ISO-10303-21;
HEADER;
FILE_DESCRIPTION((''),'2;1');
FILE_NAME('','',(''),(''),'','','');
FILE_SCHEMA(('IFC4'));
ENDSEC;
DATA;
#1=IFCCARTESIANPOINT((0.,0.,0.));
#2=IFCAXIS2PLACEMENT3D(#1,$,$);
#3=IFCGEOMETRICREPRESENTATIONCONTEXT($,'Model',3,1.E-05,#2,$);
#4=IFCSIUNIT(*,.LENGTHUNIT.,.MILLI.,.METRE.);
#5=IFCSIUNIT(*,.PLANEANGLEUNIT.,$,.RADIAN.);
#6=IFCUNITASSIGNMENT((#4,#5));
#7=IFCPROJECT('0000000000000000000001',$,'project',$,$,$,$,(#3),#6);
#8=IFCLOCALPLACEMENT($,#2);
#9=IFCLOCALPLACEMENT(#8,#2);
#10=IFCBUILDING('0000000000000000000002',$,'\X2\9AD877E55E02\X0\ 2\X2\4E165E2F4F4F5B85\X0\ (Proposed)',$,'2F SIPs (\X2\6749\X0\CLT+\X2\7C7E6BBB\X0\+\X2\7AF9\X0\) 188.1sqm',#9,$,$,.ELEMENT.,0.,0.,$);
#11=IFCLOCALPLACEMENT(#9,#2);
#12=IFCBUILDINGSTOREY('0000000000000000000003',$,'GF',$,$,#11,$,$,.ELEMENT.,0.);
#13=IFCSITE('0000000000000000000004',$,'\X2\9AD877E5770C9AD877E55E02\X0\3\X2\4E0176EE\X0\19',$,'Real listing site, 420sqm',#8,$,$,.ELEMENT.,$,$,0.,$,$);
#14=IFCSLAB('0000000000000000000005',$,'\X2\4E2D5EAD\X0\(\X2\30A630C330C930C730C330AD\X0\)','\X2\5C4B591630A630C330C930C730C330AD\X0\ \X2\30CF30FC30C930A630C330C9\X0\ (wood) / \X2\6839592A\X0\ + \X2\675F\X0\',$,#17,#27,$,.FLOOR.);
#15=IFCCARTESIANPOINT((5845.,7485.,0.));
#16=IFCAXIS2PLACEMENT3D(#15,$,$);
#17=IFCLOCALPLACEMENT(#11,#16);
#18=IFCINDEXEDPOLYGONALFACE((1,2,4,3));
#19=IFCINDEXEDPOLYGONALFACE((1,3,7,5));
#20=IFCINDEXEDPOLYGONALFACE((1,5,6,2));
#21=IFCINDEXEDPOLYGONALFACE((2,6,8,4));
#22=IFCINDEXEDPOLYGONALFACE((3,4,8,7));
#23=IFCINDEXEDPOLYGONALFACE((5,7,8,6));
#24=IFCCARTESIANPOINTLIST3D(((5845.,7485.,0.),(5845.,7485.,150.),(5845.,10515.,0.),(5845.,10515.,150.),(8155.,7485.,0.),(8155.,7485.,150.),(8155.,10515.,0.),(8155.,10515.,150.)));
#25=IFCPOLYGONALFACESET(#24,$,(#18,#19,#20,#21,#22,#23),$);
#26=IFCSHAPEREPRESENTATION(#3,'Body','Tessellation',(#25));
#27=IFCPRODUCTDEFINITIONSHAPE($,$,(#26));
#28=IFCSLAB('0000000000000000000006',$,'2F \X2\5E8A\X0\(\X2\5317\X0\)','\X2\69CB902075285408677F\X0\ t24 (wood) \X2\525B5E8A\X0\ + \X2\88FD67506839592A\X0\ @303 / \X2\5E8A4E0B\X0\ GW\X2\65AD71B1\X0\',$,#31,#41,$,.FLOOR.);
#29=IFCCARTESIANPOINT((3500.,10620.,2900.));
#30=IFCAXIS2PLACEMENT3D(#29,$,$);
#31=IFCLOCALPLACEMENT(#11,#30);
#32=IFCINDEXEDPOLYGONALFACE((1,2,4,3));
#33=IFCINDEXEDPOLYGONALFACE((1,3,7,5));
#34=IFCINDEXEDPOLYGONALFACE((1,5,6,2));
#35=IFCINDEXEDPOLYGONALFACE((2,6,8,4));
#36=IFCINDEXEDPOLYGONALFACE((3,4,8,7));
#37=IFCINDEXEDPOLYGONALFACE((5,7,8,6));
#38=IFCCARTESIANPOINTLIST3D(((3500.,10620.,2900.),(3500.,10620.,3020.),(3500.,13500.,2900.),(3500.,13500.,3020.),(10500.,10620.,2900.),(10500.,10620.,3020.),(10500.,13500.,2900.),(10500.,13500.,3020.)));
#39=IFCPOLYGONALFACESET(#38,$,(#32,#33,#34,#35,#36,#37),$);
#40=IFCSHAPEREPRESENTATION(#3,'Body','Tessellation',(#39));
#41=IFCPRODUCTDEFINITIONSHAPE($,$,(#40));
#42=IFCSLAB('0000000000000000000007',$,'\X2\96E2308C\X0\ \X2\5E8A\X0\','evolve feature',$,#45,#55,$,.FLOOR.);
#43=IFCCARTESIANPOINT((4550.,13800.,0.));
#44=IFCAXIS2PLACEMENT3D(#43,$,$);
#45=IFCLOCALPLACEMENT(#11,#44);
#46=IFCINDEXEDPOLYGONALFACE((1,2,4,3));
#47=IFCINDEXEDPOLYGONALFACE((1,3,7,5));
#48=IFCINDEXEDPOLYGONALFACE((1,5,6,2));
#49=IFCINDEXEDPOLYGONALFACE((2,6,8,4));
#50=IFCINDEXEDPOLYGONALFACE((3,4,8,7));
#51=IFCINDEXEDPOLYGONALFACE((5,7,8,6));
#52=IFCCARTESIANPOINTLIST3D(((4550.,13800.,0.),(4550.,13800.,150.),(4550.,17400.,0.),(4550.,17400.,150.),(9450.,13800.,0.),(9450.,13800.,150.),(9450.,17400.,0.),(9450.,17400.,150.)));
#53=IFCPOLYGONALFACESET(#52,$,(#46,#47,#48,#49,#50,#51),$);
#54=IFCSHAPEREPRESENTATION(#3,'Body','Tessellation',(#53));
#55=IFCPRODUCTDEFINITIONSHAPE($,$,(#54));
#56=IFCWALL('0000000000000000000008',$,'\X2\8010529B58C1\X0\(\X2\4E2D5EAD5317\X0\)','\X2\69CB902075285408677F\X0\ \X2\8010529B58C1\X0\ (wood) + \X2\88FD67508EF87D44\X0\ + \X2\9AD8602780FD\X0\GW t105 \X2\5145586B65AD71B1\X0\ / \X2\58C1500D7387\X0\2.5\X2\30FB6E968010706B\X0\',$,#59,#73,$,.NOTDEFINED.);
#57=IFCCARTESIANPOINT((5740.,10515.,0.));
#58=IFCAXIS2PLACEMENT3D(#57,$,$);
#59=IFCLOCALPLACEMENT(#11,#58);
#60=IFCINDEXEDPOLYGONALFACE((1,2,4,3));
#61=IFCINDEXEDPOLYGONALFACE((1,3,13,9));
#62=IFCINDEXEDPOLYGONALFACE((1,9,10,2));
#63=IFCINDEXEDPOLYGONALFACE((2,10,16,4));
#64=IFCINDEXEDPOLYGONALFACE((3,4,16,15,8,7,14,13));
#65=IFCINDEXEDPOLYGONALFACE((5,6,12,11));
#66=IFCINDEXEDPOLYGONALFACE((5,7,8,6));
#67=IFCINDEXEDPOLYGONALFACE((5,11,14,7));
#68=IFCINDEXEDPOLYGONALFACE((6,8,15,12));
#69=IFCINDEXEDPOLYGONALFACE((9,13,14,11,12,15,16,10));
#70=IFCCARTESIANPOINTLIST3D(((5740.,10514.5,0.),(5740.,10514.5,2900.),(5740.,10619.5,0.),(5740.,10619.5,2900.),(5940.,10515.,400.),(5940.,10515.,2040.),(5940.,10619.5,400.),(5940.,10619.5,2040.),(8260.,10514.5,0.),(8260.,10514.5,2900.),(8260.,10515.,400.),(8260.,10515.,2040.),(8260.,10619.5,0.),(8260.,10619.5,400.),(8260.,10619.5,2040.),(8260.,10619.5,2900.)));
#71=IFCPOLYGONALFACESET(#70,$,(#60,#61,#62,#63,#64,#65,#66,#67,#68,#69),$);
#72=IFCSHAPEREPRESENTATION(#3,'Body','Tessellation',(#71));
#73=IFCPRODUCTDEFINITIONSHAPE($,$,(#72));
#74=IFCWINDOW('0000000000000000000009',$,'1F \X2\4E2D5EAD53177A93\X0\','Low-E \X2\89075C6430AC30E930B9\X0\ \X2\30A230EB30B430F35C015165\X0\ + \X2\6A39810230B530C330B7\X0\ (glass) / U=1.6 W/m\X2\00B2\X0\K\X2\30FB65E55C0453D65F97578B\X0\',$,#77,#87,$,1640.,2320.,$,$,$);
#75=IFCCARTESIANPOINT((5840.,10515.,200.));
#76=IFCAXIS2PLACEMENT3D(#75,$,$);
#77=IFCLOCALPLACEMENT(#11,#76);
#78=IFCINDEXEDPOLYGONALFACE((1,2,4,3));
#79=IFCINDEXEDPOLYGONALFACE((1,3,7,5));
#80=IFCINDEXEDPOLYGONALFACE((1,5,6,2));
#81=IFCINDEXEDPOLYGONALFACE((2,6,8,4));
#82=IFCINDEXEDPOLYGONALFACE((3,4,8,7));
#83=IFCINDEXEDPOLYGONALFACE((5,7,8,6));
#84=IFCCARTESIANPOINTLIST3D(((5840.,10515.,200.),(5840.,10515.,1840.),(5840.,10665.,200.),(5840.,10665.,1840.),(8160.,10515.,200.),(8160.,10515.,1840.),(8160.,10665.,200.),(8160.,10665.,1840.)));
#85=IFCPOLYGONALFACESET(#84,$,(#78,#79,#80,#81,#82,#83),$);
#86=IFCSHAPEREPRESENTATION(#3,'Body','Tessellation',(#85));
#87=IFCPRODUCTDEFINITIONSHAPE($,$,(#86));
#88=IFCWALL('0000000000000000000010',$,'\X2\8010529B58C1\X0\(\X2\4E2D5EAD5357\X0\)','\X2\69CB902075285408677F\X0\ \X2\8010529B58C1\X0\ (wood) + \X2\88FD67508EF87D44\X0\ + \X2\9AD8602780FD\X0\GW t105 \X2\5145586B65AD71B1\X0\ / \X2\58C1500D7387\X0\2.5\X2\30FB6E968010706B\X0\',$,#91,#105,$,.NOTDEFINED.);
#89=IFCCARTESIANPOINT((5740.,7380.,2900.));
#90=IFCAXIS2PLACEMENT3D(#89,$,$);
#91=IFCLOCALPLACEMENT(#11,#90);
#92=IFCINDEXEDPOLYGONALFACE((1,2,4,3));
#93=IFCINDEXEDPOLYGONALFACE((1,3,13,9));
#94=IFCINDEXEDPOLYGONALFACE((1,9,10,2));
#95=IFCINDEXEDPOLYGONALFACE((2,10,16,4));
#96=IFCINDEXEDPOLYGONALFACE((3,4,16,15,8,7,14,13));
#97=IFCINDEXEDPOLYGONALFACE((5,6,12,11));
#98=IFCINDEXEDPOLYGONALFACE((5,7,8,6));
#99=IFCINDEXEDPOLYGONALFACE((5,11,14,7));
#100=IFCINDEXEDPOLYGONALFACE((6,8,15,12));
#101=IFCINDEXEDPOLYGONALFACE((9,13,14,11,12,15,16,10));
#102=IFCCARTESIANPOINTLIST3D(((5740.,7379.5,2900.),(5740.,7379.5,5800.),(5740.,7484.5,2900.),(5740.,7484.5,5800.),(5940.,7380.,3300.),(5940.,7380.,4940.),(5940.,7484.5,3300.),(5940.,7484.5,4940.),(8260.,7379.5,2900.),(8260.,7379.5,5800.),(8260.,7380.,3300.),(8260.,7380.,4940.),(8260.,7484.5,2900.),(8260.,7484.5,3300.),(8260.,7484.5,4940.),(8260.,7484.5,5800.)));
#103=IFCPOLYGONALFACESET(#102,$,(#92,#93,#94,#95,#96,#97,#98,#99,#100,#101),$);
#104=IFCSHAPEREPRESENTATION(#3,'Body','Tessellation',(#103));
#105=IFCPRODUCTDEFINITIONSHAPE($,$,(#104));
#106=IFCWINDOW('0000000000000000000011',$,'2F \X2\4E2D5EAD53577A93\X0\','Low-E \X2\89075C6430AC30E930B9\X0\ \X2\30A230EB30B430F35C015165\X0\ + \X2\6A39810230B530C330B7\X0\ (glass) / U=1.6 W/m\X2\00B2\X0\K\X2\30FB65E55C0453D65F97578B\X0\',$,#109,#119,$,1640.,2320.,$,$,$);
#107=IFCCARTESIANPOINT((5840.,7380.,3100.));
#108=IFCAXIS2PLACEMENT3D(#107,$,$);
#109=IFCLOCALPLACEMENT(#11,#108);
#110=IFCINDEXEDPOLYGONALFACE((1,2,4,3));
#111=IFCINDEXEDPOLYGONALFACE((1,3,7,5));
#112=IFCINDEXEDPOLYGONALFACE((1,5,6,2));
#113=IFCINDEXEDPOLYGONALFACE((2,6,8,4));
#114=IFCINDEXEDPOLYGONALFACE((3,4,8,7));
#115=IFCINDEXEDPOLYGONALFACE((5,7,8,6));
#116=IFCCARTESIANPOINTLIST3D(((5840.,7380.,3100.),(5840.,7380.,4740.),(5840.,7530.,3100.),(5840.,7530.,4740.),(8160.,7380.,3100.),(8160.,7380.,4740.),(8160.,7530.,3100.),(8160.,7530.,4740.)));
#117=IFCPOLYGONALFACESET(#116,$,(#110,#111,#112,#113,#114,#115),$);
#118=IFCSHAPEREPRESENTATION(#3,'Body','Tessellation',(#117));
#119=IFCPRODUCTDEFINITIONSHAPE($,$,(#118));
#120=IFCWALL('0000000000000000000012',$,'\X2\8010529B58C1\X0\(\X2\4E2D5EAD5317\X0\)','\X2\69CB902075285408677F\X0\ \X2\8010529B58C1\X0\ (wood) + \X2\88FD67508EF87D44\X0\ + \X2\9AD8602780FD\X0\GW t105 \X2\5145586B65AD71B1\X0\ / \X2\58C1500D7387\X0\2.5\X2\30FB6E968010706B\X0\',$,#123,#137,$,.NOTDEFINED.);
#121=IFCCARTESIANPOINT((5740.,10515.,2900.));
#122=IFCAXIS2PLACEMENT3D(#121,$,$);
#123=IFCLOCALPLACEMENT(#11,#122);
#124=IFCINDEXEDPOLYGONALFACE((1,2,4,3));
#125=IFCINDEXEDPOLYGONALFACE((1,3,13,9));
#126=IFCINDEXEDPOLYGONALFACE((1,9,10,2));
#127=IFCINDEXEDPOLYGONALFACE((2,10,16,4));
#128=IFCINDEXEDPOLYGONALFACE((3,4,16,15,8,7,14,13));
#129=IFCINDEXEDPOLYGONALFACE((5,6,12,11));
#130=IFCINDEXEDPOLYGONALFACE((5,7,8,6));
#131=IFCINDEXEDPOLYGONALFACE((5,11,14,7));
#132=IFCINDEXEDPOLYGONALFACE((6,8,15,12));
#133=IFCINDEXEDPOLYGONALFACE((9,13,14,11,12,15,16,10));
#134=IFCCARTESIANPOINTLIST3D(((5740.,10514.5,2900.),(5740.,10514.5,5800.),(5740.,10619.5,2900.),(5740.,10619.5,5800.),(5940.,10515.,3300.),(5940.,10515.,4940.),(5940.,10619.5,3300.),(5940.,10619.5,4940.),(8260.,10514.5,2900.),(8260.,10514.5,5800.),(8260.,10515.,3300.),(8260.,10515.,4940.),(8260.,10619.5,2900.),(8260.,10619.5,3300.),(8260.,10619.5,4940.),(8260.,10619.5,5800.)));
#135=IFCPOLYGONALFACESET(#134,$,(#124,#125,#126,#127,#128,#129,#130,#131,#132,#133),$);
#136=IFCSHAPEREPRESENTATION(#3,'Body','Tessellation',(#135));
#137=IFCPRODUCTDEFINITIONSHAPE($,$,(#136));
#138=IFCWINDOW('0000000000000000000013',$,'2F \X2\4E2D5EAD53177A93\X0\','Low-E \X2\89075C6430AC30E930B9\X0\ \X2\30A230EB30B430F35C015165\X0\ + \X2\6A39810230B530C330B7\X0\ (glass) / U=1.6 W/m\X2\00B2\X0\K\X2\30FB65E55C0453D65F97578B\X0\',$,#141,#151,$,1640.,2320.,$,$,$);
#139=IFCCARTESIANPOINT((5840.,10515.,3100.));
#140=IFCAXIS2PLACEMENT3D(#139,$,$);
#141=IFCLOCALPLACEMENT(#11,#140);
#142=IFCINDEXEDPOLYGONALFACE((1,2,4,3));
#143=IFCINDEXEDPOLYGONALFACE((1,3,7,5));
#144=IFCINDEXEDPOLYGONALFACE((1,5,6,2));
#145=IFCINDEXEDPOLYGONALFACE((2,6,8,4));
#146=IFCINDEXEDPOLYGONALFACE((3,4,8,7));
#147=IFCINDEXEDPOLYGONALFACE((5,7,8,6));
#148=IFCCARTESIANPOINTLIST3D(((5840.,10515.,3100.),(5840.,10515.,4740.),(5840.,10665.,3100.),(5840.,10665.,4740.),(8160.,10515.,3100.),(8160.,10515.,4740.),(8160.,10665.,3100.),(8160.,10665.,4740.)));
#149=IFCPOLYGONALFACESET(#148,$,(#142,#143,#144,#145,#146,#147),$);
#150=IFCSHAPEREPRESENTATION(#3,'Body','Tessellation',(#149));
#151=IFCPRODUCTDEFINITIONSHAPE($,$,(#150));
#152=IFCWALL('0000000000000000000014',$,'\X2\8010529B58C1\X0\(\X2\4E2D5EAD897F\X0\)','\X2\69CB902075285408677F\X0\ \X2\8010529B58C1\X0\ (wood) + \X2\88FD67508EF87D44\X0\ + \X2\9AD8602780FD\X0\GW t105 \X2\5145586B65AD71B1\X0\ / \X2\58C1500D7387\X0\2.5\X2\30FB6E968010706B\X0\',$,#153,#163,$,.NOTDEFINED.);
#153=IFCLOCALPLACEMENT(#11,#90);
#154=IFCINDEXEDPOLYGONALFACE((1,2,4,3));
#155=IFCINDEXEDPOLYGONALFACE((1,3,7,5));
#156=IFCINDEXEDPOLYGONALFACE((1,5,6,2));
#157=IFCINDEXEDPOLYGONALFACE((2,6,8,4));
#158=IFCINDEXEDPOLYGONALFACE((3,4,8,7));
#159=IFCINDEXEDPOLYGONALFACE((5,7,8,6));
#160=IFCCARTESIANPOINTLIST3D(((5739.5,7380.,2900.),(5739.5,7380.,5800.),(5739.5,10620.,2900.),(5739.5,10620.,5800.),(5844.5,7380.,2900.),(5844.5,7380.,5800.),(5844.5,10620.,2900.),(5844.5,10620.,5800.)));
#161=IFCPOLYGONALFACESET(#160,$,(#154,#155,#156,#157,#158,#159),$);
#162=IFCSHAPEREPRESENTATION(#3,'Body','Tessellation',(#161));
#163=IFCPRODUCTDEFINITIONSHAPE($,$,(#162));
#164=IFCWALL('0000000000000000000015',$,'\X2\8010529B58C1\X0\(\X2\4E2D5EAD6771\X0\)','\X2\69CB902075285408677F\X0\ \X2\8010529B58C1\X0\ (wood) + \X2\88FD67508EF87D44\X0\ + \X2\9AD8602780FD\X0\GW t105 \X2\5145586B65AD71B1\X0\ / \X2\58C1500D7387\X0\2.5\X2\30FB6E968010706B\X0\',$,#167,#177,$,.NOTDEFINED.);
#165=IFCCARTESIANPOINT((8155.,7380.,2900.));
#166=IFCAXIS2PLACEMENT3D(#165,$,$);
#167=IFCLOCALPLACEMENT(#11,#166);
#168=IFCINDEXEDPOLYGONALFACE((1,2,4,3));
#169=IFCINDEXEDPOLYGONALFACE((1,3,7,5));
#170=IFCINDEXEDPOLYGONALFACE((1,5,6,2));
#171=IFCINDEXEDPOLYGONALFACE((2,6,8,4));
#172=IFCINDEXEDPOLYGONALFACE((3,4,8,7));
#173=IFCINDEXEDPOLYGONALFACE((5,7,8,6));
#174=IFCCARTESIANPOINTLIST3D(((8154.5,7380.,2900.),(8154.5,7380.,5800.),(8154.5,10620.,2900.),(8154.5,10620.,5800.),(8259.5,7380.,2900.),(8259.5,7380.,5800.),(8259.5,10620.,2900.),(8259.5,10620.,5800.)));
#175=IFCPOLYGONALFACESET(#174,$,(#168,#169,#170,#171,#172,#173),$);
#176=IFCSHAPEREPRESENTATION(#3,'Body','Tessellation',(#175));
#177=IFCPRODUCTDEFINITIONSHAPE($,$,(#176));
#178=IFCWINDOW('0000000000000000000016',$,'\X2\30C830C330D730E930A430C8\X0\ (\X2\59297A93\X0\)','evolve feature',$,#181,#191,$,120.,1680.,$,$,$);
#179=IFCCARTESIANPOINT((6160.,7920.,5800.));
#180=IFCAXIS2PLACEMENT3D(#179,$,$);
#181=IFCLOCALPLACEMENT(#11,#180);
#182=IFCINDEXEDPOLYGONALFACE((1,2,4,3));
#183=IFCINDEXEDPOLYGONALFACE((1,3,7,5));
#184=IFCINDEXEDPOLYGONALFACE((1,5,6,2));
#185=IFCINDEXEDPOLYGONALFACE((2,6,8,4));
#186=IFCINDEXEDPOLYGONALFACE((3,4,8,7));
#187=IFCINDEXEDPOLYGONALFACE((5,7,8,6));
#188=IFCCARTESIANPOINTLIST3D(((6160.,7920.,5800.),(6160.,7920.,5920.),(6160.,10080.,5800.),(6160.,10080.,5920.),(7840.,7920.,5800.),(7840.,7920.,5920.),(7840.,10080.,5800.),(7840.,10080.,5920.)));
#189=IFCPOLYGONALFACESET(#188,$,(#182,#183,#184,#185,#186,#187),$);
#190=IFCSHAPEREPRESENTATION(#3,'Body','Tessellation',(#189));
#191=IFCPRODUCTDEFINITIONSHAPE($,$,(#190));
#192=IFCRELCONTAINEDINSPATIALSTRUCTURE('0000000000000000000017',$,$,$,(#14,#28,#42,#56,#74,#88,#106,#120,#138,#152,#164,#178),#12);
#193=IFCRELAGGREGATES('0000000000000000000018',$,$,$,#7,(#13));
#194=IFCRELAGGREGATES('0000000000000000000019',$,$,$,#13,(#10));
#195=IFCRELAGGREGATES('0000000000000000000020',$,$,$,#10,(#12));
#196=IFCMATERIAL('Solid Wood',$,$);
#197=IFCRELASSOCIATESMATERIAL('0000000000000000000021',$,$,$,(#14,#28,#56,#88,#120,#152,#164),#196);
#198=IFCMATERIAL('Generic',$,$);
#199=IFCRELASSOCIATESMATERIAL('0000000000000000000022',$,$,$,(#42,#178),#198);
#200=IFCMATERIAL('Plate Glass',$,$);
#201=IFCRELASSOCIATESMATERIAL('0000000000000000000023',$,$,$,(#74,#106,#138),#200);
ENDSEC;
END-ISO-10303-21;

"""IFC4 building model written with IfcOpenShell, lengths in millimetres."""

from ifc_helpers import new_model, si_unit, frame, frame_2d, origin, place, context, project, spatial, rectangle, extrude, material, element, fill, save


model = new_model("IFC4")

# Units and contexts
model_context = context("Model", 3, precision=1e-05, world=origin())
ifc_project = project(units=[si_unit("LENGTHUNIT", "METRE", prefix="MILLI"), si_unit("PLANEANGLEUNIT", "RADIAN")], contexts=[model_context])

# Site, building, storey
site_placement = place(None, origin())
site = spatial("IfcSite", under=ifc_project, at=site_placement, Name="高知県高知市3丁目19", ObjectType="Real listing site, 420sqm", CompositionType="ELEMENT", RefElevation=0.0)
building_placement = place(site_placement, origin())
building = spatial("IfcBuilding", under=site, at=building_placement, Name="高知市 2世帯住宅 (Proposed)", ObjectType="2F SIPs (杉CLT+籾殻+竹) 188.1sqm", CompositionType="ELEMENT", ElevationOfRefHeight=0.0, ElevationOfTerrain=0.0)
storey_placement = place(building_placement, origin())
storey = spatial("IfcBuildingStorey", under=building, at=storey_placement, Name="GF", CompositionType="ELEMENT", Elevation=0.0)

# Slabs
ifc_material_1 = material(Name="Solid Wood")
slab_1_placement = place(storey_placement, frame((5845.0, 7485.0, 0.0)))
element("IfcSlab", 1, at=slab_1_placement, inside=storey, material=ifc_material_1, Name="中庭(ウッドデッキ)", Description="屋外ウッドデッキ ハードウッド (wood) / 根太 + 束", PredefinedType="FLOOR", context=model_context, shape_type="SweptSolid", body=[
    extrude(rectangle(XDim=2310.0, YDim=3030.0, at=frame_2d((1155.0, 1515.0))), frame((5845.0, 7485.0, 0.0)), (0.0, 0.0, 1.0), 150.0),
])
slab_2_placement = place(storey_placement, frame((3500.0, 10620.0, 2900.0)))
element("IfcSlab", 2, at=slab_2_placement, inside=storey, material=ifc_material_1, Name="2F 床(北)", Description="構造用合板 t24 (wood) 剛床 + 製材根太 @303 / 床下 GW断熱", PredefinedType="FLOOR", context=model_context, shape_type="SweptSolid", body=[
    extrude(rectangle(XDim=7000.0, YDim=2880.0, at=frame_2d((3500.0, 1440.0))), frame((3500.0, 10620.0, 2900.0)), (0.0, 0.0, 1.0), 120.0),
])
ifc_material_2 = material(Name="Generic")
slab_3_placement = place(storey_placement, frame((4550.0, 13800.0, 0.0)))
element("IfcSlab", 3, at=slab_3_placement, inside=storey, material=ifc_material_2, Name="離れ 床", Description="evolve feature", PredefinedType="FLOOR", context=model_context, shape_type="SweptSolid", body=[
    extrude(rectangle(XDim=4900.0, YDim=3600.0, at=frame_2d((2450.0, 1800.0))), frame((4550.0, 13800.0, 0.0)), (0.0, 0.0, 1.0), 150.0),
])

# Wall, opening, window
wall_1_placement = place(storey_placement, frame((5740.0, 10515.0, 0.0)))
wall_1 = element("IfcWall", 4, at=wall_1_placement, inside=storey, material=ifc_material_1, Name="耐力壁(中庭北)", Description="構造用合板 耐力壁 (wood) + 製材軸組 + 高性能GW t105 充填断熱 / 壁倍率2.5・準耐火", PredefinedType="NOTDEFINED", context=model_context, shape_type="SweptSolid", body=[
    extrude(rectangle(XDim=2520.0, YDim=105.0, at=frame_2d((1260.0, 52.0))), frame((5740.0, 10515.0, 0.0)), (0.0, 0.0, 1.0), 2900.0),
])
opening_1_placement = place(storey_placement, frame((5840.0, 10515.0, 200.0)))
opening_1 = element("IfcOpeningElement", 5, at=opening_1_placement, cuts=wall_1, PredefinedType="NOTDEFINED", context=model_context, shape_type="SweptSolid", body=[
    extrude(rectangle(XDim=2320.0, YDim=150.0, at=frame_2d((1160.0, 75.0))), frame((5840.0, 10515.0, 200.0)), (0.0, 0.0, 1.0), 1640.0),
])
ifc_material_3 = material(Name="Plate Glass")
window_1_placement = place(storey_placement, frame((5840.0, 10515.0, 200.0)))
window_1 = element("IfcWindow", 6, at=window_1_placement, inside=storey, material=ifc_material_3, Name="1F 中庭北窓", Description="Low-E 複層ガラス アルゴン封入 + 樹脂サッシ (glass) / U=1.6 W/m²K・日射取得型", OverallHeight=1640.0, OverallWidth=2320.0, context=model_context, shape_type="SweptSolid", body=[
    extrude(rectangle(XDim=2320.0, YDim=150.0, at=frame_2d((1160.0, 75.0))), frame((5840.0, 10515.0, 200.0)), (0.0, 0.0, 1.0), 1640.0),
])
fill(opening_1, window_1)

# Walls, openings, windows
wall_2_placement = place(storey_placement, frame((5740.0, 7380.0, 2900.0)))
wall_2 = element("IfcWall", 7, at=wall_2_placement, inside=storey, material=ifc_material_1, Name="耐力壁(中庭南)", Description="構造用合板 耐力壁 (wood) + 製材軸組 + 高性能GW t105 充填断熱 / 壁倍率2.5・準耐火", PredefinedType="NOTDEFINED", context=model_context, shape_type="SweptSolid", body=[
    extrude(rectangle(XDim=2520.0, YDim=105.0, at=frame_2d((1260.0, 52.0))), frame((5740.0, 7380.0, 2900.0)), (0.0, 0.0, 1.0), 2900.0),
])
opening_2_placement = place(storey_placement, frame((5840.0, 7380.0, 3100.0)))
opening_2 = element("IfcOpeningElement", 8, at=opening_2_placement, cuts=wall_2, PredefinedType="NOTDEFINED", context=model_context, shape_type="SweptSolid", body=[
    extrude(rectangle(XDim=2320.0, YDim=150.0, at=frame_2d((1160.0, 75.0))), frame((5840.0, 7380.0, 3100.0)), (0.0, 0.0, 1.0), 1640.0),
])
window_2_placement = place(storey_placement, frame((5840.0, 7380.0, 3100.0)))
window_2 = element("IfcWindow", 9, at=window_2_placement, inside=storey, material=ifc_material_3, Name="2F 中庭南窓", Description="Low-E 複層ガラス アルゴン封入 + 樹脂サッシ (glass) / U=1.6 W/m²K・日射取得型", OverallHeight=1640.0, OverallWidth=2320.0, context=model_context, shape_type="SweptSolid", body=[
    extrude(rectangle(XDim=2320.0, YDim=150.0, at=frame_2d((1160.0, 75.0))), frame((5840.0, 7380.0, 3100.0)), (0.0, 0.0, 1.0), 1640.0),
])
fill(opening_2, window_2)
wall_3_placement = place(storey_placement, frame((5740.0, 10515.0, 2900.0)))
wall_3 = element("IfcWall", 10, at=wall_3_placement, inside=storey, material=ifc_material_1, Name="耐力壁(中庭北)", Description="構造用合板 耐力壁 (wood) + 製材軸組 + 高性能GW t105 充填断熱 / 壁倍率2.5・準耐火", PredefinedType="NOTDEFINED", context=model_context, shape_type="SweptSolid", body=[
    extrude(rectangle(XDim=2520.0, YDim=105.0, at=frame_2d((1260.0, 52.0))), frame((5740.0, 10515.0, 2900.0)), (0.0, 0.0, 1.0), 2900.0),
])
opening_3_placement = place(storey_placement, frame((5840.0, 10515.0, 3100.0)))
opening_3 = element("IfcOpeningElement", 11, at=opening_3_placement, cuts=wall_3, PredefinedType="NOTDEFINED", context=model_context, shape_type="SweptSolid", body=[
    extrude(rectangle(XDim=2320.0, YDim=150.0, at=frame_2d((1160.0, 75.0))), frame((5840.0, 10515.0, 3100.0)), (0.0, 0.0, 1.0), 1640.0),
])
window_3_placement = place(storey_placement, frame((5840.0, 10515.0, 3100.0)))
window_3 = element("IfcWindow", 12, at=window_3_placement, inside=storey, material=ifc_material_3, Name="2F 中庭北窓", Description="Low-E 複層ガラス アルゴン封入 + 樹脂サッシ (glass) / U=1.6 W/m²K・日射取得型", OverallHeight=1640.0, OverallWidth=2320.0, context=model_context, shape_type="SweptSolid", body=[
    extrude(rectangle(XDim=2320.0, YDim=150.0, at=frame_2d((1160.0, 75.0))), frame((5840.0, 10515.0, 3100.0)), (0.0, 0.0, 1.0), 1640.0),
])
fill(opening_3, window_3)

# Walls
wall_4_placement = place(storey_placement, frame((5740.0, 7380.0, 2900.0)))
element("IfcWall", 13, at=wall_4_placement, inside=storey, material=ifc_material_1, Name="耐力壁(中庭西)", Description="構造用合板 耐力壁 (wood) + 製材軸組 + 高性能GW t105 充填断熱 / 壁倍率2.5・準耐火", PredefinedType="NOTDEFINED", context=model_context, shape_type="SweptSolid", body=[
    extrude(rectangle(XDim=105.0, YDim=3240.0, at=frame_2d((52.0, 1620.0))), frame((5740.0, 7380.0, 2900.0)), (0.0, 0.0, 1.0), 2900.0),
])
wall_5_placement = place(storey_placement, frame((8155.0, 7380.0, 2900.0)))
element("IfcWall", 14, at=wall_5_placement, inside=storey, material=ifc_material_1, Name="耐力壁(中庭東)", Description="構造用合板 耐力壁 (wood) + 製材軸組 + 高性能GW t105 充填断熱 / 壁倍率2.5・準耐火", PredefinedType="NOTDEFINED", context=model_context, shape_type="SweptSolid", body=[
    extrude(rectangle(XDim=105.0, YDim=3240.0, at=frame_2d((52.0, 1620.0))), frame((8155.0, 7380.0, 2900.0)), (0.0, 0.0, 1.0), 2900.0),
])

# Window
window_4_placement = place(storey_placement, frame((6160.0, 7920.0, 5800.0)))
element("IfcWindow", 15, at=window_4_placement, inside=storey, material=ifc_material_2, Name="トップライト (天窓)", Description="evolve feature", OverallHeight=120.0, OverallWidth=1680.0, context=model_context, shape_type="SweptSolid", body=[
    extrude(rectangle(XDim=1680.0, YDim=2160.0, at=frame_2d((840.0, 1080.0))), frame((6160.0, 7920.0, 5800.0)), (0.0, 0.0, 1.0), 120.0),
])

save(model, "model.ifc")
